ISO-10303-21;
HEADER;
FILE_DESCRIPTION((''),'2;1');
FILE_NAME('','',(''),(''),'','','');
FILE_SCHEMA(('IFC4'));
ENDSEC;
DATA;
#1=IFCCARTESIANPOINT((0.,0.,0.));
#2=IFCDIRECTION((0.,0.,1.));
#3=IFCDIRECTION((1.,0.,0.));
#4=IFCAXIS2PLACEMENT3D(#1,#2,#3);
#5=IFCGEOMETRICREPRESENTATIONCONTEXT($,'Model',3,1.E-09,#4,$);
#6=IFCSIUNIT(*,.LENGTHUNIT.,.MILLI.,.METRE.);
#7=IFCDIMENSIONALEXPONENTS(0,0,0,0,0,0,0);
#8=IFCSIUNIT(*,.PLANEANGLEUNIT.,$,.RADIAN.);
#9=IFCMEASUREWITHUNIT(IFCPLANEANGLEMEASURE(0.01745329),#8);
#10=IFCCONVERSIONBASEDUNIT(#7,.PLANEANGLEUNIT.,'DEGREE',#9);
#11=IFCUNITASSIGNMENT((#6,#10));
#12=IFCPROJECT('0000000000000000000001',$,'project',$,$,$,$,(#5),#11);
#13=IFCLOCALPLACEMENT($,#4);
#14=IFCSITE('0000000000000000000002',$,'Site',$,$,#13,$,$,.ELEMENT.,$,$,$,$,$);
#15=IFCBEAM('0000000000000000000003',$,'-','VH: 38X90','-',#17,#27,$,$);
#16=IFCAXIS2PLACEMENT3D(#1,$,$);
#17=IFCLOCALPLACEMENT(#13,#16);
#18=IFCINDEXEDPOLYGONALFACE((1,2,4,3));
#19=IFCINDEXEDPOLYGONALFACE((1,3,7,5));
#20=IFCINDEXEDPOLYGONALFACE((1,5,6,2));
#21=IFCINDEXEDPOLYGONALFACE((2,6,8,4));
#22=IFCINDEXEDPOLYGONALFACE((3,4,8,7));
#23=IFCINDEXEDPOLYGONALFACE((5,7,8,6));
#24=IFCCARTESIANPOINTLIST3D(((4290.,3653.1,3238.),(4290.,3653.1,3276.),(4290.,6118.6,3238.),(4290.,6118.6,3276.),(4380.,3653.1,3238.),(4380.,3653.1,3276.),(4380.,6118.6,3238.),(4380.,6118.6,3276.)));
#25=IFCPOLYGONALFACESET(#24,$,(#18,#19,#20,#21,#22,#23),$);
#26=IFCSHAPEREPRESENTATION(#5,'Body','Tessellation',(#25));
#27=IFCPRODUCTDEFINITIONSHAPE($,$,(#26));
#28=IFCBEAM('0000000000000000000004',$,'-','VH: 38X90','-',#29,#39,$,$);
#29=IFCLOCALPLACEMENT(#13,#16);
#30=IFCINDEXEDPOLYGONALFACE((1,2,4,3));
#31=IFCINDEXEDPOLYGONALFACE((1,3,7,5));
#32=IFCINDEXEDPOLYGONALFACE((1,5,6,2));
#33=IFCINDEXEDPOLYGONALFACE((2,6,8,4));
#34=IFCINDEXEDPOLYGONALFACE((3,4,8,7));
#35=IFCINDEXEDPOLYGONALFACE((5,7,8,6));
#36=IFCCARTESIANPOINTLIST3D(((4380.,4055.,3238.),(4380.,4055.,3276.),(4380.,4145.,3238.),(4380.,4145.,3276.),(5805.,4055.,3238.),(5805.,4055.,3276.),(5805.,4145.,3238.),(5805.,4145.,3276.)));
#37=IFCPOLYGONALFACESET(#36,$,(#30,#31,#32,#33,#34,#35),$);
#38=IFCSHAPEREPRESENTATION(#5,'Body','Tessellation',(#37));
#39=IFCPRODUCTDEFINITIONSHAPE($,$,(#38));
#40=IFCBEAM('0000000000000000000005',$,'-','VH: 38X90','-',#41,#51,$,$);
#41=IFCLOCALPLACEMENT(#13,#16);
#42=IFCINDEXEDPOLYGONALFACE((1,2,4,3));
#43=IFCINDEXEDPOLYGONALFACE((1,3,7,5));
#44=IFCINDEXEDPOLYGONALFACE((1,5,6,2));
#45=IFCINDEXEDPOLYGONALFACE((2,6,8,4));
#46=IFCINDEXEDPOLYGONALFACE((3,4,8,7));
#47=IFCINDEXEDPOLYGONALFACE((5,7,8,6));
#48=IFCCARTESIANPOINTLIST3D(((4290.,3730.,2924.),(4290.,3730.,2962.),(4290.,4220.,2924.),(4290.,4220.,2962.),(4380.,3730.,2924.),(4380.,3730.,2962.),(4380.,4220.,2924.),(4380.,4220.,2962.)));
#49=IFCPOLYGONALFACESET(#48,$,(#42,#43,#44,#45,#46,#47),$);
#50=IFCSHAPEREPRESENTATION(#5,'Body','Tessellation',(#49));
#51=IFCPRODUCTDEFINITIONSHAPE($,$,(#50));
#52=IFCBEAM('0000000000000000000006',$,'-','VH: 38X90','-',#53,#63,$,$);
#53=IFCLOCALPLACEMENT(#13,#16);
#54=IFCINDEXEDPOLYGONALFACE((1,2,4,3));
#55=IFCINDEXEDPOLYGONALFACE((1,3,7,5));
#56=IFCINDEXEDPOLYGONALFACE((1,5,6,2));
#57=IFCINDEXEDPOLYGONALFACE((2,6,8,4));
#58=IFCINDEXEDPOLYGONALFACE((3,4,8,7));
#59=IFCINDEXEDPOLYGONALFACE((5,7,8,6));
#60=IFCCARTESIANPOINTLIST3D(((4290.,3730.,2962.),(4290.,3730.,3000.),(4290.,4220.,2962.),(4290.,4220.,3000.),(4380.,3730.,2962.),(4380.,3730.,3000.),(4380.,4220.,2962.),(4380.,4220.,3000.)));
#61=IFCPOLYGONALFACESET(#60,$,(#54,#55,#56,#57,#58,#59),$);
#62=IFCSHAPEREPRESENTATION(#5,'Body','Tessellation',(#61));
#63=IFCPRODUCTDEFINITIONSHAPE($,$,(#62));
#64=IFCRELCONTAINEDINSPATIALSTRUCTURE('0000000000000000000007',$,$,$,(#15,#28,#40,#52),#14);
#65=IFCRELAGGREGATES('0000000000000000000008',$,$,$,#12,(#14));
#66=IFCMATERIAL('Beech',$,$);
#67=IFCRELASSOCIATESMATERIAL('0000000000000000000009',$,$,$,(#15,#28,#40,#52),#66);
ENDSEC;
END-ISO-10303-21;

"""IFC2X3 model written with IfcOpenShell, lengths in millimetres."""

from ifc_helpers import new_model, entity, si_unit, converted_unit, frame, origin, origin_with_axes, origin_2d, place, context, project, spatial, rectangle, extrude, material, element, save


model = new_model("IFC2X3")

# Units and contexts
model_context = context("Model", 3, precision=1e-09, world=origin_with_axes())
ifc_project = project(units=[si_unit("LENGTHUNIT", "METRE", prefix="MILLI"), converted_unit("PLANEANGLEUNIT", "DEGREE", entity("IfcPlaneAngleMeasure", 0.01745329), si_unit("PLANEANGLEUNIT", "RADIAN"), dimensions=[0, 0, 0, 0, 0, 0, 0])], contexts=[model_context])

# Site
site_placement = place(None, origin_with_axes())
site = spatial("IfcSite", under=ifc_project, at=site_placement, Name="Site", CompositionType="ELEMENT")

# Shared definitions
ifc_material = material(Name="Beech")

# Beams
beam_1_placement = place(None, frame((4335.0, 6118.6, 3257.0), z_axis=(-0.00001, 1.0, 0.0), x_axis=(0.0, 0.0, -1.0)))
element("IfcBeam", 1, at=beam_1_placement, inside=site, material=ifc_material, Name="-", Description="VH: 38X90", ObjectType="-", context=model_context, shape_type="SweptSolid", body=[
    extrude(rectangle(XDim=38.0, YDim=90.0, at=origin_2d()), origin(), (0.0, 0.0, -1.0), 2465.5),
])
beam_2_placement = place(None, frame((4380.0, 4100.0, 3257.0), z_axis=(-1.0, 0.0, 0.0), x_axis=(0.0, 0.0, -1.0)))
element("IfcBeam", 2, at=beam_2_placement, inside=site, material=ifc_material, Name="-", Description="VH: 38X90", ObjectType="-", context=model_context, shape_type="SweptSolid", body=[
    extrude(rectangle(XDim=38.0, YDim=90.0, at=origin_2d()), origin(), (0.0, 0.0, -1.0), 1425.0),
])
for number, where, z_axis, x_axis, name in (
    (3, (4335.0, 3730.0, 2943.0), (0.0, -1.0, 0.0), (0.0, 0.0, -1.0), "-"),
    (4, (4335.0, 3730.0, 2981.0), (0.0, -1.0, 0.0), (0.0, 0.0, -1.0), "-"),
):
    element("IfcBeam", number, at=place(None, frame(where, z_axis=z_axis, x_axis=x_axis)), inside=site, material=ifc_material, Name=name, Description="VH: 38X90", ObjectType="-", context=model_context, shape_type="SweptSolid", body=[
        extrude(rectangle(XDim=38.0, YDim=90.0, at=origin_2d()), origin(), (0.0, 0.0, -1.0), 490.0),
    ])

save(model, "model.ifc")
